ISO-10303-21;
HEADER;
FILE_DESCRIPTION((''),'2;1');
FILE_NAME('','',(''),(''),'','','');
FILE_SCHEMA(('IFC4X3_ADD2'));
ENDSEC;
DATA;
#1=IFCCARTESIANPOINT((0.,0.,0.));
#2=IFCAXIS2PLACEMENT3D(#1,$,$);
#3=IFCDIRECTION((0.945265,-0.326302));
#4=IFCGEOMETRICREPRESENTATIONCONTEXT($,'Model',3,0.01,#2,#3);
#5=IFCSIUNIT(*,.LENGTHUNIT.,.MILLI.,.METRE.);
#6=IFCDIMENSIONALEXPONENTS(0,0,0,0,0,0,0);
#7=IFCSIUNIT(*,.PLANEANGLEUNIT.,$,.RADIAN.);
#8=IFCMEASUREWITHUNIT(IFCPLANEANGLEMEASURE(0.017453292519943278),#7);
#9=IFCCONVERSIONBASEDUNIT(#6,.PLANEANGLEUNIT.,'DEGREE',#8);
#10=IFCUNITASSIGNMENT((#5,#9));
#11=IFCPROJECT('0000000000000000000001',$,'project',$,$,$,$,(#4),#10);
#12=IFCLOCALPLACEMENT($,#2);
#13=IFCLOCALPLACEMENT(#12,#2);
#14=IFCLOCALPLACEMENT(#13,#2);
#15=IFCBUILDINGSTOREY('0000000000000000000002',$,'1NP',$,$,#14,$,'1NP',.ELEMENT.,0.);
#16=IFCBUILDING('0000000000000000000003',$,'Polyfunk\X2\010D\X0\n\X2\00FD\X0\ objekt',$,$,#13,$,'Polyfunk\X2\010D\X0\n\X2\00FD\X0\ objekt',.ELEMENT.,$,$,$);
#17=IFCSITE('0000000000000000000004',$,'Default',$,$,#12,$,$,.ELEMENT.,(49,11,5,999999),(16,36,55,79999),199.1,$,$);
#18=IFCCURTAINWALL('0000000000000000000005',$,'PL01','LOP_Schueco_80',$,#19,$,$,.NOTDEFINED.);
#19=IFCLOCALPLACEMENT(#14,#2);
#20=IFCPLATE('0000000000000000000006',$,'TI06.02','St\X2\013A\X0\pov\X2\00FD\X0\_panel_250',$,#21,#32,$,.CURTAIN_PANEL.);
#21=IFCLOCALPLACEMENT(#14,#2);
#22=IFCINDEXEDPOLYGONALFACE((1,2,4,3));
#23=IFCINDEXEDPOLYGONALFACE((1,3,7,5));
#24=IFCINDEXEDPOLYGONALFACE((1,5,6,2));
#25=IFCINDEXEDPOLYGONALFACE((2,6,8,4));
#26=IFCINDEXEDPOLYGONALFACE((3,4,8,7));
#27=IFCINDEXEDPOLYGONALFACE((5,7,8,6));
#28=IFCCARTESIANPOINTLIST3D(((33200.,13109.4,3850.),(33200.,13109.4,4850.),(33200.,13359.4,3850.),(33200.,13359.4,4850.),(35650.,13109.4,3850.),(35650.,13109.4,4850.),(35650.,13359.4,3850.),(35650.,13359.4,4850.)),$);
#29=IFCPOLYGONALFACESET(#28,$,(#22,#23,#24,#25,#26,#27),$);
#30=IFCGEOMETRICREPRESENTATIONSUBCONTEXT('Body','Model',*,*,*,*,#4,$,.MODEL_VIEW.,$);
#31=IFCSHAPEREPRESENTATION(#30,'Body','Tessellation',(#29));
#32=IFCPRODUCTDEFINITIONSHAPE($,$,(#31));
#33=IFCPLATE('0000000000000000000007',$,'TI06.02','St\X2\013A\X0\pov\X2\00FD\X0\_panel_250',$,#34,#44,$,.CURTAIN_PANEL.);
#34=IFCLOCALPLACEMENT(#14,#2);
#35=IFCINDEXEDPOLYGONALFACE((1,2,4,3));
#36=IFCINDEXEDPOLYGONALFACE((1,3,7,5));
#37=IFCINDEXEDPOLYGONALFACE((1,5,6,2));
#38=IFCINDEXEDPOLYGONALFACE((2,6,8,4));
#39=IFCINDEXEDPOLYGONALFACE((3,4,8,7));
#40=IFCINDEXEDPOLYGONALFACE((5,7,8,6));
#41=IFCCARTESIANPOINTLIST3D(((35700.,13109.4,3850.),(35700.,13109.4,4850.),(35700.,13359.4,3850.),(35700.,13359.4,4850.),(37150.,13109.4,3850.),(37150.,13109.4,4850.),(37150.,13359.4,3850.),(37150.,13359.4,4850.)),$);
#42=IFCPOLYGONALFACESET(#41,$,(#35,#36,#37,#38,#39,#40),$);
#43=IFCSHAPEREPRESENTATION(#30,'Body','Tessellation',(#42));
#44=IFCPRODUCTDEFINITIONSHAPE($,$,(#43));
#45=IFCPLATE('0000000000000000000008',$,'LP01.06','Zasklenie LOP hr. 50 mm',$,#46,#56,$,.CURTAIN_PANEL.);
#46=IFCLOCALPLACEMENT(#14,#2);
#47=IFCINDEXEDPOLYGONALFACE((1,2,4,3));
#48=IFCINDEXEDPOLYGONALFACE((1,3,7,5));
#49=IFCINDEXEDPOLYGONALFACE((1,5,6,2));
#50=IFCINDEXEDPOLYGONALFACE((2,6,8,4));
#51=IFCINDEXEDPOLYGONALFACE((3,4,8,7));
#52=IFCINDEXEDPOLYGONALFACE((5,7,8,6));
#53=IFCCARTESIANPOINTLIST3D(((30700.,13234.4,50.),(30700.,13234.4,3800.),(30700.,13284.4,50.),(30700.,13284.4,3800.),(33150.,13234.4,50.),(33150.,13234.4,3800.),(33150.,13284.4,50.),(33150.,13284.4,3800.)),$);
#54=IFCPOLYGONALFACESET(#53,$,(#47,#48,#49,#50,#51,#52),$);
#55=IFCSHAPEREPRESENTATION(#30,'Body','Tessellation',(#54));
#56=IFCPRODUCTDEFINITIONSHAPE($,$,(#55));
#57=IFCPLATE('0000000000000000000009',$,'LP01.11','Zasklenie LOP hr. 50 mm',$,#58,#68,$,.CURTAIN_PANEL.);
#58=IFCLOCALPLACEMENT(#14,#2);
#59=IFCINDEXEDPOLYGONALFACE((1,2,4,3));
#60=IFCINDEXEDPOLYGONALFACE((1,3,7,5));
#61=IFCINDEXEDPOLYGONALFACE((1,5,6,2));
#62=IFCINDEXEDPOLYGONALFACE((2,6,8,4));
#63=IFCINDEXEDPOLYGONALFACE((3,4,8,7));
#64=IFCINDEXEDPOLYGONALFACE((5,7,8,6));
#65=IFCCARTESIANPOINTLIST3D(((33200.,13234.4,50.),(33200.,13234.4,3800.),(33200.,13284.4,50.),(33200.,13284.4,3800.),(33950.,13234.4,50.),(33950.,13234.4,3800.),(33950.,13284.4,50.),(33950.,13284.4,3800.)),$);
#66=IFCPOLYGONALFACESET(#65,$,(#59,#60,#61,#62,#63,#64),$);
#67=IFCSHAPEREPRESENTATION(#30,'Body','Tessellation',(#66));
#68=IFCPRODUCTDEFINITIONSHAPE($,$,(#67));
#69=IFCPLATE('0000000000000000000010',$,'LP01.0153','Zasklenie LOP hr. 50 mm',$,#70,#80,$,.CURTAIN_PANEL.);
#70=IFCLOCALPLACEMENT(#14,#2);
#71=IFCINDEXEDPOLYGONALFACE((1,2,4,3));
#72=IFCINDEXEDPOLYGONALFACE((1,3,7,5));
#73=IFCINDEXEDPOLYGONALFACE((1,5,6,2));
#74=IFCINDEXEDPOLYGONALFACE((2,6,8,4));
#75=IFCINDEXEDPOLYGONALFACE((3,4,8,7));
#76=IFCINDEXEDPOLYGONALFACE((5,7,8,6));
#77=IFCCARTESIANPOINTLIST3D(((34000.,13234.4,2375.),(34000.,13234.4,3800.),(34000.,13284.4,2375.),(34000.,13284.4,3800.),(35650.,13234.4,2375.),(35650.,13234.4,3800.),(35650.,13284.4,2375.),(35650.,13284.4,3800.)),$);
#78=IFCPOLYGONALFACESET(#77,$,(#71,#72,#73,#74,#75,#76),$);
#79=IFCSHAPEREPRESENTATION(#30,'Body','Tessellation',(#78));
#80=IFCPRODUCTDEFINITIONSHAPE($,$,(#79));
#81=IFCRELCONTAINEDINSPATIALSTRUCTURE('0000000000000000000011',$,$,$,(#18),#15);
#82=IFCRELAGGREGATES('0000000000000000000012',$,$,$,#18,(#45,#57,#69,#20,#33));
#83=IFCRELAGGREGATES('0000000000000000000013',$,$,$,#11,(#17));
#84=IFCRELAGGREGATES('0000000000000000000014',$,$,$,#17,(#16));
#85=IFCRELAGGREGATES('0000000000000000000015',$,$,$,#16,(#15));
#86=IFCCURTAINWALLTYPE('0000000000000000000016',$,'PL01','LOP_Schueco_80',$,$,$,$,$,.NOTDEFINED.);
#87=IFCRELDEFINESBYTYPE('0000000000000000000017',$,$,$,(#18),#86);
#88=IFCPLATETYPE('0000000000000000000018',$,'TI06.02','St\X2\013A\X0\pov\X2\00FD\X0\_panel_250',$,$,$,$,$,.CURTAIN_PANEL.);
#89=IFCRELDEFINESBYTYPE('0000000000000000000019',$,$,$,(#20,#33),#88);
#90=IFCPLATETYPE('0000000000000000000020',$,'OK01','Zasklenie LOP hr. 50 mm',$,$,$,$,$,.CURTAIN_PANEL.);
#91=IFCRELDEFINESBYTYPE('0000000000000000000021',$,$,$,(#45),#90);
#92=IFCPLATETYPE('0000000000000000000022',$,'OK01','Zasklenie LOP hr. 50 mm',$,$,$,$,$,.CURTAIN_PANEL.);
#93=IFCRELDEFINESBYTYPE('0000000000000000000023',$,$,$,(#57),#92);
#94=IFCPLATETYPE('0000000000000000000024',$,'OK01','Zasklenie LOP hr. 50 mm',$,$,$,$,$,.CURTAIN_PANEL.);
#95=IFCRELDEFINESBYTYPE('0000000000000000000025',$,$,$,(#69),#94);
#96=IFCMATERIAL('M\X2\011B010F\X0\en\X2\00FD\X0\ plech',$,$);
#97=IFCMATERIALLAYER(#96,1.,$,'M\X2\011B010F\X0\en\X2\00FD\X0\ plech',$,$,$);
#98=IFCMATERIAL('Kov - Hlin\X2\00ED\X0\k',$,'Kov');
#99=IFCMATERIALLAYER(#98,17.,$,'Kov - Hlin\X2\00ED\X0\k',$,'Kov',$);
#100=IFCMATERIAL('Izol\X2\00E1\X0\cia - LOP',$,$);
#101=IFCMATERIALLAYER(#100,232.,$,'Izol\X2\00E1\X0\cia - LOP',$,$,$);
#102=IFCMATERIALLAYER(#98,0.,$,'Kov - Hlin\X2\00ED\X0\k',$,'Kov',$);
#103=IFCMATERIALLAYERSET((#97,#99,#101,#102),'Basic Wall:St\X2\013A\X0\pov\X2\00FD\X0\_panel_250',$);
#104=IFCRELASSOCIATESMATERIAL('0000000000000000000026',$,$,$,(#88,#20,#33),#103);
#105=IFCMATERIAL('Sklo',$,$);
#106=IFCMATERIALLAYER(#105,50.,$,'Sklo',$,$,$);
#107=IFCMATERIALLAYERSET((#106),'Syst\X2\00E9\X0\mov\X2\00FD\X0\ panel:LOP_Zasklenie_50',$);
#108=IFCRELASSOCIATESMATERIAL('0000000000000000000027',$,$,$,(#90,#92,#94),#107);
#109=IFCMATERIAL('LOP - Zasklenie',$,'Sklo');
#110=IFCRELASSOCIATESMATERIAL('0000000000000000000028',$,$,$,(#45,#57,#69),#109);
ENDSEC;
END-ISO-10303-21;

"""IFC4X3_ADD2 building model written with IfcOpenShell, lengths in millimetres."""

from ifc_helpers import new_model, entity, si_unit, converted_unit, direction, frame, frame_2d, origin, origin_2d_with_axis, place, context, subcontext, project, spatial, rectangle, extrude, source, transform, mapped, material, layer, layer_set, layer_usage, type_object, type_shapes, element, aggregate, save


model = new_model("IFC4X3_ADD2")

# Units and contexts
model_context = context("Model", 3, precision=0.01, world=origin(), true_north=direction((0.945265, -0.326302)))
body_context = subcontext(model_context, "Body", "Model", "MODEL_VIEW")
ifc_project = project(units=[si_unit("LENGTHUNIT", "METRE", prefix="MILLI"), converted_unit("PLANEANGLEUNIT", "DEGREE", entity("IfcPlaneAngleMeasure", 0.017453292519943278), si_unit("PLANEANGLEUNIT", "RADIAN"), dimensions=[0, 0, 0, 0, 0, 0, 0])], contexts=[model_context])

# Site, building, storey
site_placement = place(None, origin())
site = spatial("IfcSite", under=ifc_project, at=site_placement, Name="Default", CompositionType="ELEMENT", RefLatitude=(49, 11, 5, 999999), RefLongitude=(16, 36, 55, 79999), RefElevation=199.1)
building_placement = place(site_placement, origin())
building = spatial("IfcBuilding", under=site, at=building_placement, Name="Polyfunkčný objekt", LongName="Polyfunkčný objekt", CompositionType="ELEMENT")
storey_placement = place(building_placement, origin())
storey = spatial("IfcBuildingStorey", under=building, at=storey_placement, Name="1NP", LongName="1NP", CompositionType="ELEMENT", Elevation=0.0)

# Curtain wall, plates
curtain_wall_type = type_object("IfcCurtainWallType", Name="PL01", Description="LOP_Schueco_80", PredefinedType="NOTDEFINED")
curtain_wall_placement = place(storey_placement, origin())
curtain_wall = element("IfcCurtainWall", 1, at=curtain_wall_placement, inside=storey, type_object=curtain_wall_type, Name="PL01", Description="LOP_Schueco_80", PredefinedType="NOTDEFINED")
ifc_material_1 = material(Name="Měďený plech")
ifc_layer_1 = layer(ifc_material_1, 1.0, Name="Měďený plech")
ifc_material_2 = material(Name="Kov - Hliník", Category="Kov")
ifc_layer_2 = layer(ifc_material_2, 17.0, Name="Kov - Hliník", Category="Kov")
ifc_material_3 = material(Name="Izolácia - LOP")
ifc_layer_3 = layer(ifc_material_3, 232.0, Name="Izolácia - LOP")
ifc_layer_4 = layer(ifc_material_2, 0.0, Name="Kov - Hliník", Category="Kov")
ifc_layer_set_1 = layer_set([ifc_layer_1, ifc_layer_2, ifc_layer_3, ifc_layer_4], Name="Basic Wall:Stĺpový_panel_250")
ifc_layer_usage_1 = layer_usage(ifc_layer_set_1, "AXIS2", "NEGATIVE", 125.0)
plate_type_1 = type_object("IfcPlateType", Name="TI06.02", Description="Stĺpový_panel_250", PredefinedType="CURTAIN_PANEL", material=ifc_layer_set_1)
plate_1_placement = place(storey_placement, frame((33200.0, 13234.4, 3850.0)))
plate_1 = element("IfcPlate", 2, at=plate_1_placement, type_object=plate_type_1, material=ifc_layer_usage_1, Name="TI06.02", Description="Stĺpový_panel_250", PredefinedType="CURTAIN_PANEL", context=body_context, shape_type="SweptSolid", body=[
    extrude(rectangle(XDim=250.0, YDim=2450.0, at=frame_2d((0.0, 0.0), x_axis=(1.0, 0.0))), frame((1225.0, 0.0, 0.0), z_axis=(0.0, 0.0, 1.0), x_axis=(0.0, 1.0, 0.0)), (0.0, 0.0, 1.0), 1000.0),
])
ifc_layer_usage_2 = layer_usage(ifc_layer_set_1, "AXIS2", "NEGATIVE", 125.0)
plate_2_placement = place(storey_placement, frame((35700.0, 13234.4, 3850.0)))
plate_2 = element("IfcPlate", 3, at=plate_2_placement, type_object=plate_type_1, material=ifc_layer_usage_2, Name="TI06.02", Description="Stĺpový_panel_250", PredefinedType="CURTAIN_PANEL", context=body_context, shape_type="SweptSolid", body=[
    extrude(rectangle(XDim=250.0, YDim=1450.0, at=origin_2d_with_axis()), frame((725.0, 0.0, 0.0), z_axis=(0.0, 0.0, 1.0), x_axis=(0.0, 1.0, 0.0)), (0.0, 0.0, 1.0), 1000.0),
])
ifc_material_4 = material(Name="LOP - Zasklenie", Category="Sklo")
ifc_material_5 = material(Name="Sklo")
ifc_layer_5 = layer(ifc_material_5, 50.0, Name="Sklo")
ifc_layer_set_2 = layer_set([ifc_layer_5], Name="Systémový panel:LOP_Zasklenie_50")
plate_type_2 = type_object("IfcPlateType", Name="OK01", Description="Zasklenie LOP hr. 50 mm", PredefinedType="CURTAIN_PANEL", material=ifc_layer_set_2)
shared_shape_1 = source(origin(), body_context, "Body", "SweptSolid", [
    extrude(rectangle(XDim=3750.0, YDim=2450.0, at=frame_2d((-141.7, 0.0), x_axis=(1.0, 0.0))), frame((0.0, 0.0, 2016.7), z_axis=(0.0, 1.0, 0.0), x_axis=(0.0, 0.0, 1.0)), (0.0, 0.0, 1.0), 50.0),
])
type_shapes(plate_type_2, [shared_shape_1])
plate_3_placement = place(curtain_wall_placement, frame((31925.0, 13234.4, 50.0)))
plate_3 = element("IfcPlate", 4, at=plate_3_placement, type_object=plate_type_2, material=ifc_material_4, Name="LP01.06", Description="Zasklenie LOP hr. 50 mm", PredefinedType="CURTAIN_PANEL", context=body_context, shape_type="MappedRepresentation", body=[
    mapped(shared_shape_1, transform((0.0, 0.0, 0.0), scale=1.0)),
])
plate_type_3 = type_object("IfcPlateType", Name="OK01", Description="Zasklenie LOP hr. 50 mm", PredefinedType="CURTAIN_PANEL", material=ifc_layer_set_2)
shared_shape_2 = source(origin(), body_context, "Body", "SweptSolid", [
    extrude(rectangle(XDim=3750.0, YDim=750.0, at=frame_2d((-141.7, 0.0), x_axis=(1.0, 0.0))), frame((0.0, 0.0, 2016.7), z_axis=(0.0, 1.0, 0.0), x_axis=(0.0, 0.0, 1.0)), (0.0, 0.0, 1.0), 50.0),
])
type_shapes(plate_type_3, [shared_shape_2])
plate_4_placement = place(curtain_wall_placement, frame((33575.0, 13234.4, 50.0)))
plate_4 = element("IfcPlate", 5, at=plate_4_placement, type_object=plate_type_3, material=ifc_material_4, Name="LP01.11", Description="Zasklenie LOP hr. 50 mm", PredefinedType="CURTAIN_PANEL", context=body_context, shape_type="MappedRepresentation", body=[
    mapped(shared_shape_2, transform((0.0, 0.0, 0.0), scale=1.0)),
])
plate_type_4 = type_object("IfcPlateType", Name="OK01", Description="Zasklenie LOP hr. 50 mm", PredefinedType="CURTAIN_PANEL", material=ifc_layer_set_2)
shared_shape_3 = source(origin(), body_context, "Body", "SweptSolid", [
    extrude(rectangle(XDim=50.0, YDim=1650.0, at=origin_2d_with_axis()), frame((0.0, 25.0, 0.0), z_axis=(0.0, 0.0, 1.0), x_axis=(0.0, 1.0, 0.0)), (0.0, 0.0, 1.0), 1425.0),
])
type_shapes(plate_type_4, [shared_shape_3])
plate_5_placement = place(curtain_wall_placement, frame((34825.0, 13234.4, 2375.0)))
plate_5 = element("IfcPlate", 6, at=plate_5_placement, type_object=plate_type_4, material=ifc_material_4, Name="LP01.0153", Description="Zasklenie LOP hr. 50 mm", PredefinedType="CURTAIN_PANEL", context=body_context, shape_type="MappedRepresentation", body=[
    mapped(shared_shape_3, transform((0.0, 0.0, 0.0), scale=1.0)),
])
aggregate(curtain_wall, [plate_3, plate_4, plate_5, plate_1, plate_2])

save(model, "model.ifc")
